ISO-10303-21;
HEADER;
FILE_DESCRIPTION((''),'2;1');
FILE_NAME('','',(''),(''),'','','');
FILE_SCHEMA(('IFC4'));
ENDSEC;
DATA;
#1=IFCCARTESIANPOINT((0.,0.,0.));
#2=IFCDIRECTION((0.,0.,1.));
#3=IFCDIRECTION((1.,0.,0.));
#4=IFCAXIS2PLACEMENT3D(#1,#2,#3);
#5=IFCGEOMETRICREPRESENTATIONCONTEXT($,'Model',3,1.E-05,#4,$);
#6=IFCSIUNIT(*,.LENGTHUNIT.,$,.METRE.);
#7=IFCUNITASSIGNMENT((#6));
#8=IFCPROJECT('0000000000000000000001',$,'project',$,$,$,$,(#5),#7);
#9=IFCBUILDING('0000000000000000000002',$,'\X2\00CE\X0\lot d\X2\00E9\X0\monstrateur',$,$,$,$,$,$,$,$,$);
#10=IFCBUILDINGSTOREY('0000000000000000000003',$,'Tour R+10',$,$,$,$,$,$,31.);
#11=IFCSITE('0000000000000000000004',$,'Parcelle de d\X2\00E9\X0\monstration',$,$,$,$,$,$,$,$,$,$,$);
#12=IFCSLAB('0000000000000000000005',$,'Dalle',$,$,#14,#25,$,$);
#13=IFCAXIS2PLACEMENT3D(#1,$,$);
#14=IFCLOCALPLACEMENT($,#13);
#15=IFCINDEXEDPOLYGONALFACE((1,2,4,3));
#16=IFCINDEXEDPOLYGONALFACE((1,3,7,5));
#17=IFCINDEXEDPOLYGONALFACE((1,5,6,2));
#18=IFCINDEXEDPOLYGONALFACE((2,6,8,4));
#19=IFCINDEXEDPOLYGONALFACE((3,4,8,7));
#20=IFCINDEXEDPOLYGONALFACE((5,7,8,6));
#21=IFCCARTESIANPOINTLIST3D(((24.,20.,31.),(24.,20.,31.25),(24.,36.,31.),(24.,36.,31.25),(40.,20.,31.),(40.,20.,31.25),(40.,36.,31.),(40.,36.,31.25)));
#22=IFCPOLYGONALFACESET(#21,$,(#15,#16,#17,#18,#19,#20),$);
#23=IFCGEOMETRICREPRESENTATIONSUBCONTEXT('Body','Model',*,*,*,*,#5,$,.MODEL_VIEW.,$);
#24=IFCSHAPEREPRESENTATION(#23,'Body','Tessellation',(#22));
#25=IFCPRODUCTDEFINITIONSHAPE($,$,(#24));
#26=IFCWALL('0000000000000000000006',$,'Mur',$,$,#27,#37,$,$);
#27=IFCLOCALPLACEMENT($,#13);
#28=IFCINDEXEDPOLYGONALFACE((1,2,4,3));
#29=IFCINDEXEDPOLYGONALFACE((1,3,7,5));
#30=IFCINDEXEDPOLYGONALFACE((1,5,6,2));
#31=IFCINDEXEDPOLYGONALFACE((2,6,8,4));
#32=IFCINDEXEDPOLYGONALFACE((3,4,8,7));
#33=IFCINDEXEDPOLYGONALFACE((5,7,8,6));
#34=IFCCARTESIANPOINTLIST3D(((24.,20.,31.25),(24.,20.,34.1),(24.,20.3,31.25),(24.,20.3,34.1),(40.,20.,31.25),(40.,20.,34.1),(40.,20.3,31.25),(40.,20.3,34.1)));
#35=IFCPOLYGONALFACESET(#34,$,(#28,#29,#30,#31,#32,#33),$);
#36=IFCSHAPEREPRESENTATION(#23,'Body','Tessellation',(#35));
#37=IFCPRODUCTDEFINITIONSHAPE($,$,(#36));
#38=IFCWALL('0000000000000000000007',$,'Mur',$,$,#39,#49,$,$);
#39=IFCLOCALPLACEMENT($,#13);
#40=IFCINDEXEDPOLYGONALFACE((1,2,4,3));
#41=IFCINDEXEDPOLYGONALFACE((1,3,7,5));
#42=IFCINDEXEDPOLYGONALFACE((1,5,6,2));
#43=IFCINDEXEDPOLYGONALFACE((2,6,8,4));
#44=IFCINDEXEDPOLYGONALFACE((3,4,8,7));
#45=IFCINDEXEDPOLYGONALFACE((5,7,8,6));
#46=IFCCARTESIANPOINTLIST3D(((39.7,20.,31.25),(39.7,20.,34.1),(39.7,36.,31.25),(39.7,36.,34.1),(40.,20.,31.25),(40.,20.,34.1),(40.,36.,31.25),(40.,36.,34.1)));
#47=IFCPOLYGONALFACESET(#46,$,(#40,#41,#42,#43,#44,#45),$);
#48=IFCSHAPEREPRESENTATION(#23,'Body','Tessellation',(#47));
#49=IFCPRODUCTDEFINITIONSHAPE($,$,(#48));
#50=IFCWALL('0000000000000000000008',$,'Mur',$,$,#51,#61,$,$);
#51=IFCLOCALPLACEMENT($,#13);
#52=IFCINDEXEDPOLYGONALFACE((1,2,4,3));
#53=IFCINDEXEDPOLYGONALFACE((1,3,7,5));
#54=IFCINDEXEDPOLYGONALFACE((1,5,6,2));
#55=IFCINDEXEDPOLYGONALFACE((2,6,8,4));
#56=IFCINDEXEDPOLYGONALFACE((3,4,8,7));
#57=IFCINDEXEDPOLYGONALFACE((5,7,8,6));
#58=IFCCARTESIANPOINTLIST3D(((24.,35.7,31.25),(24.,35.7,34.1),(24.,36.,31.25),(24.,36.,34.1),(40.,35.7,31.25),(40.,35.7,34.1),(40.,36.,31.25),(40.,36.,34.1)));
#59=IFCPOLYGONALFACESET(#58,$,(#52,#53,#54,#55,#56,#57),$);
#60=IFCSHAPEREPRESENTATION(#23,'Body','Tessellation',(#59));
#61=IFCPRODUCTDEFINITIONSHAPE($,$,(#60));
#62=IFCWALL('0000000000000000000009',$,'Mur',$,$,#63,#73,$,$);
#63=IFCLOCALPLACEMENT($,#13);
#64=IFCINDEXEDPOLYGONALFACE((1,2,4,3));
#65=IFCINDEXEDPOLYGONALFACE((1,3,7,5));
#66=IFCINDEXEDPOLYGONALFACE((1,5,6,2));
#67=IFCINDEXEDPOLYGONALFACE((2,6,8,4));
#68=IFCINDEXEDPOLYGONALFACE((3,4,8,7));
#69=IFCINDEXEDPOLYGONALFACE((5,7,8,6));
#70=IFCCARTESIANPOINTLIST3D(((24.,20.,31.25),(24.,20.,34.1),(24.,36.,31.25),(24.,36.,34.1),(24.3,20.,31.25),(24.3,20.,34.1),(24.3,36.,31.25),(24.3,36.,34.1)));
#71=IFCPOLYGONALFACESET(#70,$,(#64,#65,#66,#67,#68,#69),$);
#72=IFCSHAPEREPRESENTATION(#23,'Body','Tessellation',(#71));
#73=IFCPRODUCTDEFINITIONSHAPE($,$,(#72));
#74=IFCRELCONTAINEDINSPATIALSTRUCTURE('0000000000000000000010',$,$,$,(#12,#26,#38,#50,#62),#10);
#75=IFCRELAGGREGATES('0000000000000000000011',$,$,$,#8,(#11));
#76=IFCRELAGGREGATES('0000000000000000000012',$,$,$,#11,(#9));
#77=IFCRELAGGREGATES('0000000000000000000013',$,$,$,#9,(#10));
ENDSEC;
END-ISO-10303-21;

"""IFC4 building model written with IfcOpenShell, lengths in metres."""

from ifc_helpers import new_model, si_unit, frame, origin_with_axes, place, context, subcontext, project, spatial, indexed_curve, outline, extrude, element, save


model = new_model("IFC4")

# Units and contexts
model_context = context("Model", 3, precision=1e-05, world=origin_with_axes())
body_context = subcontext(model_context, "Body", "Model", "MODEL_VIEW")
ifc_project = project(units=[si_unit("LENGTHUNIT", "METRE")], contexts=[model_context])

# Site, building, storey
site = spatial("IfcSite", under=ifc_project, Name="Parcelle de démonstration")
building = spatial("IfcBuilding", under=site, Name="Îlot démonstrateur")
storey = spatial("IfcBuildingStorey", under=building, Name="Tour R+10", Elevation=31.0)

# Slab
slab_placement = place(None, frame((0.0, 0.0, 31.0), z_axis=(0.0, 0.0, 1.0), x_axis=(1.0, 0.0, 0.0)))
element("IfcSlab", 1, at=slab_placement, inside=storey, Name="Dalle", context=body_context, shape_type="SweptSolid", body=[
    extrude(outline(indexed_curve([(24.0, 20.0), (40.0, 20.0), (40.0, 36.0), (24.0, 36.0)])), None, (0.0, 0.0, 1.0), 0.25),
])

# Walls
for number, where, z_axis, x_axis, name in (
    (2, (24.0, 20.0, 31.25), (0.0, 0.0, 1.0), (1.0, 0.0, 0.0), "Mur"),
    (3, (40.0, 20.0, 31.25), (0.0, 0.0, 1.0), (0.0, 1.0, 0.0), "Mur"),
    (4, (40.0, 36.0, 31.25), (0.0, 0.0, 1.0), (-1.0, 0.0, 0.0), "Mur"),
    (5, (24.0, 36.0, 31.25), (0.0, 0.0, 1.0), (0.0, -1.0, 0.0), "Mur"),
):
    element("IfcWall", number, at=place(None, frame(where, z_axis=z_axis, x_axis=x_axis)), inside=storey, Name=name, context=body_context, shape_type="SweptSolid", body=[
        extrude(outline(indexed_curve([(0.0, 0.0), (0.0, 0.3), (16.0, 0.3), (16.0, 0.0), (0.0, 0.0)], self_intersect=False)), origin_with_axes(), (0.0, 0.0, 1.0), 2.85),
    ])

save(model, "model.ifc")
